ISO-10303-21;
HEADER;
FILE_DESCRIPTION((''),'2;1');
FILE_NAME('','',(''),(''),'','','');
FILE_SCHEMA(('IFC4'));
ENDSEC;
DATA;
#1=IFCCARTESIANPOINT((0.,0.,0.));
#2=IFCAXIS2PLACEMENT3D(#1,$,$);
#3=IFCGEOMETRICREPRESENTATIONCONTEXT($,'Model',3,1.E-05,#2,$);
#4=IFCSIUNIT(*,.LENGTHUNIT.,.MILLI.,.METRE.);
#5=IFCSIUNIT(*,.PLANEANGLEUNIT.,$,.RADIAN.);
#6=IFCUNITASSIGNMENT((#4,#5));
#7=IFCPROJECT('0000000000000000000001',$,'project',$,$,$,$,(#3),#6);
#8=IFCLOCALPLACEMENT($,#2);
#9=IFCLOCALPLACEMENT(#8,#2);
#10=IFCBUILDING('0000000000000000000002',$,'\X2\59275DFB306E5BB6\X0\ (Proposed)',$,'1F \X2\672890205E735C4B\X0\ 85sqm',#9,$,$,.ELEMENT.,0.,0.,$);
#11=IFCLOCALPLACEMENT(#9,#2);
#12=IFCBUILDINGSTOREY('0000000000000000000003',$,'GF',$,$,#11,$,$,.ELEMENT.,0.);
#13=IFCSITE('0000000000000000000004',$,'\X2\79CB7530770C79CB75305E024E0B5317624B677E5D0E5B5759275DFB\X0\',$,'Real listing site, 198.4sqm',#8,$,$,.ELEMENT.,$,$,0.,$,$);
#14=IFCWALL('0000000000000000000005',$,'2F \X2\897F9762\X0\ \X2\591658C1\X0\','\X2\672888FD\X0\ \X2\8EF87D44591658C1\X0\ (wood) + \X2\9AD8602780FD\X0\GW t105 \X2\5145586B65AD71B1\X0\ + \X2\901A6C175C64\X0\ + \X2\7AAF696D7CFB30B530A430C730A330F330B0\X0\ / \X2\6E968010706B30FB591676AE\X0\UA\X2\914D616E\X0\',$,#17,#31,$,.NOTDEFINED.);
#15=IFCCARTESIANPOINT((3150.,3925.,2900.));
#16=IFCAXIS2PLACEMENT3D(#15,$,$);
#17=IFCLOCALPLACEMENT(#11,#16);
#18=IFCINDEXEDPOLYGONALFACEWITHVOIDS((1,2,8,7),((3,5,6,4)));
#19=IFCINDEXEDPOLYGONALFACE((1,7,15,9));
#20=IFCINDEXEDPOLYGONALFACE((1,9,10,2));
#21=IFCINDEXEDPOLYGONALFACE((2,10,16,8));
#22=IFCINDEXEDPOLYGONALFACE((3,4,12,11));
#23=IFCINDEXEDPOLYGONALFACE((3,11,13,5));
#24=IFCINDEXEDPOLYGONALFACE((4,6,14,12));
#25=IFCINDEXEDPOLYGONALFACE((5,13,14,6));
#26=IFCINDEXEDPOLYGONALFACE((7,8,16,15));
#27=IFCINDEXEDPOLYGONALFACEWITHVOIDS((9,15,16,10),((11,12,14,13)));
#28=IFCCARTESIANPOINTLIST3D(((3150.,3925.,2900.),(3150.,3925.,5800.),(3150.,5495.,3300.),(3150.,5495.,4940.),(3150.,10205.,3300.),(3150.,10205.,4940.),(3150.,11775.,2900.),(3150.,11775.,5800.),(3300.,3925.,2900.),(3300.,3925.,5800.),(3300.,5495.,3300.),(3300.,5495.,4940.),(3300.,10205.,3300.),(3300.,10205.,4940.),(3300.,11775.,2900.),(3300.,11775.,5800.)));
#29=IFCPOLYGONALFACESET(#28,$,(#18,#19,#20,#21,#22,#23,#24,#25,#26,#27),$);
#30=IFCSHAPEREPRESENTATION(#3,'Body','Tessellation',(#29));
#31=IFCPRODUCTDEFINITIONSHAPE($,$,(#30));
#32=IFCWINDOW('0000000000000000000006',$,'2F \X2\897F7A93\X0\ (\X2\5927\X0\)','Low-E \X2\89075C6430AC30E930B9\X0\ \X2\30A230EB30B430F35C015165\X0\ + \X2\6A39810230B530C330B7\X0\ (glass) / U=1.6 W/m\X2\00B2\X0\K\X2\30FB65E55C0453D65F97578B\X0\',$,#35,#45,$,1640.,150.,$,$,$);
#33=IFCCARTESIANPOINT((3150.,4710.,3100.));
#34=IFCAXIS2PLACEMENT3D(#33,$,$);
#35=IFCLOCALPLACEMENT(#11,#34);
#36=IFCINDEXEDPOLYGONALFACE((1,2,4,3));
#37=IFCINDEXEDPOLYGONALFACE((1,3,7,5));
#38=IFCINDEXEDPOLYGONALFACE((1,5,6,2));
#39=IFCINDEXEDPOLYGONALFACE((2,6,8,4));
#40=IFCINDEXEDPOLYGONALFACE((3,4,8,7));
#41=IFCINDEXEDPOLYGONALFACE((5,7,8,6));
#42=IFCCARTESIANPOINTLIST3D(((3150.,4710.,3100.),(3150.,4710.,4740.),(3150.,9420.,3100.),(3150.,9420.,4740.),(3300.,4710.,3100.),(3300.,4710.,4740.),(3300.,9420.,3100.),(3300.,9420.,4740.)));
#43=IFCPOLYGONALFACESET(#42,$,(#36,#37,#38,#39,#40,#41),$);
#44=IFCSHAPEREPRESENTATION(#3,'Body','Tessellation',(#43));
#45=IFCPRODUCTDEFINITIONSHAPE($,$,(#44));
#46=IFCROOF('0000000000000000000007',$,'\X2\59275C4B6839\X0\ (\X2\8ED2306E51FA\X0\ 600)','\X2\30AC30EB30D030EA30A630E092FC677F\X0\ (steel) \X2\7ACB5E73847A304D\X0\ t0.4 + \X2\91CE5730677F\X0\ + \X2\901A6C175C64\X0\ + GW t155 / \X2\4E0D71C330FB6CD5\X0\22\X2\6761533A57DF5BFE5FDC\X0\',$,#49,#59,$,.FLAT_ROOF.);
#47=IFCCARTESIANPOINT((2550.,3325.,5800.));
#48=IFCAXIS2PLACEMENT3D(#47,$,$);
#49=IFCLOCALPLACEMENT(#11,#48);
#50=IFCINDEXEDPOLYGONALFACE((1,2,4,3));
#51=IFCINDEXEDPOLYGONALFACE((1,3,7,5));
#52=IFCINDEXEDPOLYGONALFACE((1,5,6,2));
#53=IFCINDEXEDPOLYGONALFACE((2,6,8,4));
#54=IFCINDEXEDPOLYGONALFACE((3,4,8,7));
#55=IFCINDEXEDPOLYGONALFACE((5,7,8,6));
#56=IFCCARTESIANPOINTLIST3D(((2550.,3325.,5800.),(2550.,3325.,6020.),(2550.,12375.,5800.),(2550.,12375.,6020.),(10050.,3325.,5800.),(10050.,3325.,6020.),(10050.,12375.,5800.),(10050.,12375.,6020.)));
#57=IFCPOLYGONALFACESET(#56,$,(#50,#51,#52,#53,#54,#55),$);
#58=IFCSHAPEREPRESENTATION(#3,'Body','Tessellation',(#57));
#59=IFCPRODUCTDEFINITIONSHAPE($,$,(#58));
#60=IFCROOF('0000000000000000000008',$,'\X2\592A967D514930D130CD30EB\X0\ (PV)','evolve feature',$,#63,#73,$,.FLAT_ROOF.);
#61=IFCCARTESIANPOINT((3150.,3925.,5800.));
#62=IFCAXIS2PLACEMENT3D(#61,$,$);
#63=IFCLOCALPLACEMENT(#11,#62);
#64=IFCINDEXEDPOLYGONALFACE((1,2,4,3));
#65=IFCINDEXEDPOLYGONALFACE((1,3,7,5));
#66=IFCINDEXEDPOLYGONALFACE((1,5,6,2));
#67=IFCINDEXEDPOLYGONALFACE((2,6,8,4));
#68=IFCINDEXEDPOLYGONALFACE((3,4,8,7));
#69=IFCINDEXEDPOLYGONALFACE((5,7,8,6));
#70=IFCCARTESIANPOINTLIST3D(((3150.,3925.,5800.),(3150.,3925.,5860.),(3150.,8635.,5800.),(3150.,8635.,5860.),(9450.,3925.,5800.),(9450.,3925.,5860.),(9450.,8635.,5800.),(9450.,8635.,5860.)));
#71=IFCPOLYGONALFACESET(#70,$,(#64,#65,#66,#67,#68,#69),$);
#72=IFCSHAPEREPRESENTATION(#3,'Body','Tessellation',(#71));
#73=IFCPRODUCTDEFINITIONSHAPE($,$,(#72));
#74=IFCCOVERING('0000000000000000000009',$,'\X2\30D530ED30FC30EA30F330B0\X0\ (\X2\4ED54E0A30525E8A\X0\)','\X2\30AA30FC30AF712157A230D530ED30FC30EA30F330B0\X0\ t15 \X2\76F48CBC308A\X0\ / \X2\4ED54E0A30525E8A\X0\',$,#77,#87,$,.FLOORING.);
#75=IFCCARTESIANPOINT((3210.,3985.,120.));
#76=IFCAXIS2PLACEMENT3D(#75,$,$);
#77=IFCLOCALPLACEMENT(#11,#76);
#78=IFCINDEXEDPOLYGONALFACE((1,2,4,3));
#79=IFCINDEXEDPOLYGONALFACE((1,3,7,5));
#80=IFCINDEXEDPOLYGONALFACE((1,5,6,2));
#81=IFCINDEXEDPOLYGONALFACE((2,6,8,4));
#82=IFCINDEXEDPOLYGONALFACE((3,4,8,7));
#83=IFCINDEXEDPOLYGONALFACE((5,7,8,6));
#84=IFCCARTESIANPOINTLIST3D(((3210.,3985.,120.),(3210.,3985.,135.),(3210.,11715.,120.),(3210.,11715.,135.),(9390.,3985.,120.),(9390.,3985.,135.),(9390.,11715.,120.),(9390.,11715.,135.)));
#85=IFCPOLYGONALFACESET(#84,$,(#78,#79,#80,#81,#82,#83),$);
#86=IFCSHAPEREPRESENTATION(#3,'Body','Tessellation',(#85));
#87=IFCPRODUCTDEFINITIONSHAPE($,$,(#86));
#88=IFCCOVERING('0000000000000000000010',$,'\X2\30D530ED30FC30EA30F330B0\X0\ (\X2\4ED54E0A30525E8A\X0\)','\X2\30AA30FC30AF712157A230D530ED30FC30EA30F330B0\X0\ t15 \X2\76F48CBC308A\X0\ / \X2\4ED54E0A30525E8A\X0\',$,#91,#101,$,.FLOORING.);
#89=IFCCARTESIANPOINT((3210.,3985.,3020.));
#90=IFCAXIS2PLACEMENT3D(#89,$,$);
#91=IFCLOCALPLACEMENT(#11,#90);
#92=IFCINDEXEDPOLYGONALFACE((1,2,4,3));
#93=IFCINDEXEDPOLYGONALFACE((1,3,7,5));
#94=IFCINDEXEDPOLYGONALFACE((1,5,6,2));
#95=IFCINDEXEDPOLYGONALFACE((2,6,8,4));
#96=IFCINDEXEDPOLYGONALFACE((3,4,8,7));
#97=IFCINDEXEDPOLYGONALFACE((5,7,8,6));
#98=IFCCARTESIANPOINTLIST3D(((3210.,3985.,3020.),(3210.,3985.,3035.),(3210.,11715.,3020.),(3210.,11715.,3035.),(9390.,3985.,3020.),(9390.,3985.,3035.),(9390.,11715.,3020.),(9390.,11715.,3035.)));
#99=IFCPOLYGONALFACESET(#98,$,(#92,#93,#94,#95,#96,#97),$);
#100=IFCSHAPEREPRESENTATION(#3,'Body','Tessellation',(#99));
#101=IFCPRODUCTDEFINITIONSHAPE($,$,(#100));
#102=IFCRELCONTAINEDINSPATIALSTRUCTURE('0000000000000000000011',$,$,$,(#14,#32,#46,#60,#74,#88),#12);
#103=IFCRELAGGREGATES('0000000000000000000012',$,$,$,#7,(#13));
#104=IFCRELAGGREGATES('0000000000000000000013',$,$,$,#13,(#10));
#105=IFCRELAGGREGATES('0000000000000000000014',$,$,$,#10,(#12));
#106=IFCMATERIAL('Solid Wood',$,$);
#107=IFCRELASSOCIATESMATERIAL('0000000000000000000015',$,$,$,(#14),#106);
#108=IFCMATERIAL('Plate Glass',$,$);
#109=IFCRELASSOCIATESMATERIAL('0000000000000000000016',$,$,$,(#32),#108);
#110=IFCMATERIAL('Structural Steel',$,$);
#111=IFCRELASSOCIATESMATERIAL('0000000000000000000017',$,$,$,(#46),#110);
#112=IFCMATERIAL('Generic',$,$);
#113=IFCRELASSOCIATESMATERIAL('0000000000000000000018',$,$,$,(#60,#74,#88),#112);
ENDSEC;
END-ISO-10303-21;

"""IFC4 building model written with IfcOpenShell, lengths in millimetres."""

from ifc_helpers import new_model, si_unit, frame, frame_2d, origin, place, context, project, spatial, rectangle, extrude, material, element, fill, save


model = new_model("IFC4")

# Units and contexts
model_context = context("Model", 3, precision=1e-05, world=origin())
ifc_project = project(units=[si_unit("LENGTHUNIT", "METRE", prefix="MILLI"), si_unit("PLANEANGLEUNIT", "RADIAN")], contexts=[model_context])

# Site, building, storey
site_placement = place(None, origin())
site = spatial("IfcSite", under=ifc_project, at=site_placement, Name="秋田県秋田市下北手松崎字大巻", ObjectType="Real listing site, 198.4sqm", CompositionType="ELEMENT", RefElevation=0.0)
building_placement = place(site_placement, origin())
building = spatial("IfcBuilding", under=site, at=building_placement, Name="大巻の家 (Proposed)", ObjectType="1F 木造平屋 85sqm", CompositionType="ELEMENT", ElevationOfRefHeight=0.0, ElevationOfTerrain=0.0)
storey_placement = place(building_placement, origin())
storey = spatial("IfcBuildingStorey", under=building, at=storey_placement, Name="GF", CompositionType="ELEMENT", Elevation=0.0)

# Shared definitions
ifc_material_1 = material(Name="Solid Wood")
ifc_material_2 = material(Name="Generic")

# Shared definitions
ifc_material_3 = material(Name="Plate Glass")

# Wall, opening, window
wall_1_placement = place(storey_placement, frame((3150.0, 3925.0, 2900.0)))
wall_1 = element("IfcWall", 1, at=wall_1_placement, inside=storey, material=ifc_material_1, Name="2F 西面 外壁", Description="木製 軸組外壁 (wood) + 高性能GW t105 充填断熱 + 通気層 + 窯業系サイディング / 準耐火・外皮UA配慮", PredefinedType="NOTDEFINED", context=model_context, shape_type="SweptSolid", body=[
    extrude(rectangle(XDim=150.0, YDim=7850.0, at=frame_2d((75.0, 3925.0))), frame((3150.0, 3925.0, 2900.0)), (0.0, 0.0, 1.0), 2900.0),
])
opening_1_placement = place(storey_placement, frame((3150.0, 4710.0, 3100.0)))
opening_1 = element("IfcOpeningElement", 2, at=opening_1_placement, cuts=wall_1, PredefinedType="NOTDEFINED", context=model_context, shape_type="SweptSolid", body=[
    extrude(rectangle(XDim=150.0, YDim=4710.0, at=frame_2d((75.0, 2355.0))), frame((3150.0, 4710.0, 3100.0)), (0.0, 0.0, 1.0), 1640.0),
])
window_1_placement = place(storey_placement, frame((3150.0, 4710.0, 3100.0)))
window_1 = element("IfcWindow", 3, at=window_1_placement, inside=storey, material=ifc_material_3, Name="2F 西窓 (大)", Description="Low-E 複層ガラス アルゴン封入 + 樹脂サッシ (glass) / U=1.6 W/m²K・日射取得型", OverallHeight=1640.0, OverallWidth=150.0, context=model_context, shape_type="SweptSolid", body=[
    extrude(rectangle(XDim=150.0, YDim=4710.0, at=frame_2d((75.0, 2355.0))), frame((3150.0, 4710.0, 3100.0)), (0.0, 0.0, 1.0), 1640.0),
])
fill(opening_1, window_1)

# Roofs
ifc_material_4 = material(Name="Structural Steel")
roof_1_placement = place(storey_placement, frame((2550.0, 3325.0, 5800.0)))
element("IfcRoof", 4, at=roof_1_placement, inside=storey, material=ifc_material_4, Name="大屋根 (軒の出 600)", Description="ガルバリウム鋼板 (steel) 立平葺き t0.4 + 野地板 + 通気層 + GW t155 / 不燃・法22条区域対応", PredefinedType="FLAT_ROOF", context=model_context, shape_type="SweptSolid", body=[
    extrude(rectangle(XDim=7500.0, YDim=9050.0, at=frame_2d((3750.0, 4525.0))), frame((2550.0, 3325.0, 5800.0)), (0.0, 0.0, 1.0), 220.0),
])
roof_2_placement = place(storey_placement, frame((3150.0, 3925.0, 5800.0)))
element("IfcRoof", 5, at=roof_2_placement, inside=storey, material=ifc_material_2, Name="太陽光パネル (PV)", Description="evolve feature", PredefinedType="FLAT_ROOF", context=model_context, shape_type="SweptSolid", body=[
    extrude(rectangle(XDim=6300.0, YDim=4710.0, at=frame_2d((3150.0, 2355.0))), frame((3150.0, 3925.0, 5800.0)), (0.0, 0.0, 1.0), 60.0),
])

# Coverings
covering_1_placement = place(storey_placement, frame((3210.0, 3985.0, 120.0)))
element("IfcCovering", 6, at=covering_1_placement, inside=storey, material=ifc_material_2, Name="フローリング (仕上げ床)", Description="オーク無垢フローリング t15 直貼り / 仕上げ床", PredefinedType="FLOORING", context=model_context, shape_type="SweptSolid", body=[
    extrude(rectangle(XDim=6180.0, YDim=7730.0, at=frame_2d((3090.0, 3865.0))), frame((3210.0, 3985.0, 120.0)), (0.0, 0.0, 1.0), 15.0),
])
covering_2_placement = place(storey_placement, frame((3210.0, 3985.0, 3020.0)))
element("IfcCovering", 7, at=covering_2_placement, inside=storey, material=ifc_material_2, Name="フローリング (仕上げ床)", Description="オーク無垢フローリング t15 直貼り / 仕上げ床", PredefinedType="FLOORING", context=model_context, shape_type="SweptSolid", body=[
    extrude(rectangle(XDim=6180.0, YDim=7730.0, at=frame_2d((3090.0, 3865.0))), frame((3210.0, 3985.0, 3020.0)), (0.0, 0.0, 1.0), 15.0),
])

save(model, "model.ifc")
